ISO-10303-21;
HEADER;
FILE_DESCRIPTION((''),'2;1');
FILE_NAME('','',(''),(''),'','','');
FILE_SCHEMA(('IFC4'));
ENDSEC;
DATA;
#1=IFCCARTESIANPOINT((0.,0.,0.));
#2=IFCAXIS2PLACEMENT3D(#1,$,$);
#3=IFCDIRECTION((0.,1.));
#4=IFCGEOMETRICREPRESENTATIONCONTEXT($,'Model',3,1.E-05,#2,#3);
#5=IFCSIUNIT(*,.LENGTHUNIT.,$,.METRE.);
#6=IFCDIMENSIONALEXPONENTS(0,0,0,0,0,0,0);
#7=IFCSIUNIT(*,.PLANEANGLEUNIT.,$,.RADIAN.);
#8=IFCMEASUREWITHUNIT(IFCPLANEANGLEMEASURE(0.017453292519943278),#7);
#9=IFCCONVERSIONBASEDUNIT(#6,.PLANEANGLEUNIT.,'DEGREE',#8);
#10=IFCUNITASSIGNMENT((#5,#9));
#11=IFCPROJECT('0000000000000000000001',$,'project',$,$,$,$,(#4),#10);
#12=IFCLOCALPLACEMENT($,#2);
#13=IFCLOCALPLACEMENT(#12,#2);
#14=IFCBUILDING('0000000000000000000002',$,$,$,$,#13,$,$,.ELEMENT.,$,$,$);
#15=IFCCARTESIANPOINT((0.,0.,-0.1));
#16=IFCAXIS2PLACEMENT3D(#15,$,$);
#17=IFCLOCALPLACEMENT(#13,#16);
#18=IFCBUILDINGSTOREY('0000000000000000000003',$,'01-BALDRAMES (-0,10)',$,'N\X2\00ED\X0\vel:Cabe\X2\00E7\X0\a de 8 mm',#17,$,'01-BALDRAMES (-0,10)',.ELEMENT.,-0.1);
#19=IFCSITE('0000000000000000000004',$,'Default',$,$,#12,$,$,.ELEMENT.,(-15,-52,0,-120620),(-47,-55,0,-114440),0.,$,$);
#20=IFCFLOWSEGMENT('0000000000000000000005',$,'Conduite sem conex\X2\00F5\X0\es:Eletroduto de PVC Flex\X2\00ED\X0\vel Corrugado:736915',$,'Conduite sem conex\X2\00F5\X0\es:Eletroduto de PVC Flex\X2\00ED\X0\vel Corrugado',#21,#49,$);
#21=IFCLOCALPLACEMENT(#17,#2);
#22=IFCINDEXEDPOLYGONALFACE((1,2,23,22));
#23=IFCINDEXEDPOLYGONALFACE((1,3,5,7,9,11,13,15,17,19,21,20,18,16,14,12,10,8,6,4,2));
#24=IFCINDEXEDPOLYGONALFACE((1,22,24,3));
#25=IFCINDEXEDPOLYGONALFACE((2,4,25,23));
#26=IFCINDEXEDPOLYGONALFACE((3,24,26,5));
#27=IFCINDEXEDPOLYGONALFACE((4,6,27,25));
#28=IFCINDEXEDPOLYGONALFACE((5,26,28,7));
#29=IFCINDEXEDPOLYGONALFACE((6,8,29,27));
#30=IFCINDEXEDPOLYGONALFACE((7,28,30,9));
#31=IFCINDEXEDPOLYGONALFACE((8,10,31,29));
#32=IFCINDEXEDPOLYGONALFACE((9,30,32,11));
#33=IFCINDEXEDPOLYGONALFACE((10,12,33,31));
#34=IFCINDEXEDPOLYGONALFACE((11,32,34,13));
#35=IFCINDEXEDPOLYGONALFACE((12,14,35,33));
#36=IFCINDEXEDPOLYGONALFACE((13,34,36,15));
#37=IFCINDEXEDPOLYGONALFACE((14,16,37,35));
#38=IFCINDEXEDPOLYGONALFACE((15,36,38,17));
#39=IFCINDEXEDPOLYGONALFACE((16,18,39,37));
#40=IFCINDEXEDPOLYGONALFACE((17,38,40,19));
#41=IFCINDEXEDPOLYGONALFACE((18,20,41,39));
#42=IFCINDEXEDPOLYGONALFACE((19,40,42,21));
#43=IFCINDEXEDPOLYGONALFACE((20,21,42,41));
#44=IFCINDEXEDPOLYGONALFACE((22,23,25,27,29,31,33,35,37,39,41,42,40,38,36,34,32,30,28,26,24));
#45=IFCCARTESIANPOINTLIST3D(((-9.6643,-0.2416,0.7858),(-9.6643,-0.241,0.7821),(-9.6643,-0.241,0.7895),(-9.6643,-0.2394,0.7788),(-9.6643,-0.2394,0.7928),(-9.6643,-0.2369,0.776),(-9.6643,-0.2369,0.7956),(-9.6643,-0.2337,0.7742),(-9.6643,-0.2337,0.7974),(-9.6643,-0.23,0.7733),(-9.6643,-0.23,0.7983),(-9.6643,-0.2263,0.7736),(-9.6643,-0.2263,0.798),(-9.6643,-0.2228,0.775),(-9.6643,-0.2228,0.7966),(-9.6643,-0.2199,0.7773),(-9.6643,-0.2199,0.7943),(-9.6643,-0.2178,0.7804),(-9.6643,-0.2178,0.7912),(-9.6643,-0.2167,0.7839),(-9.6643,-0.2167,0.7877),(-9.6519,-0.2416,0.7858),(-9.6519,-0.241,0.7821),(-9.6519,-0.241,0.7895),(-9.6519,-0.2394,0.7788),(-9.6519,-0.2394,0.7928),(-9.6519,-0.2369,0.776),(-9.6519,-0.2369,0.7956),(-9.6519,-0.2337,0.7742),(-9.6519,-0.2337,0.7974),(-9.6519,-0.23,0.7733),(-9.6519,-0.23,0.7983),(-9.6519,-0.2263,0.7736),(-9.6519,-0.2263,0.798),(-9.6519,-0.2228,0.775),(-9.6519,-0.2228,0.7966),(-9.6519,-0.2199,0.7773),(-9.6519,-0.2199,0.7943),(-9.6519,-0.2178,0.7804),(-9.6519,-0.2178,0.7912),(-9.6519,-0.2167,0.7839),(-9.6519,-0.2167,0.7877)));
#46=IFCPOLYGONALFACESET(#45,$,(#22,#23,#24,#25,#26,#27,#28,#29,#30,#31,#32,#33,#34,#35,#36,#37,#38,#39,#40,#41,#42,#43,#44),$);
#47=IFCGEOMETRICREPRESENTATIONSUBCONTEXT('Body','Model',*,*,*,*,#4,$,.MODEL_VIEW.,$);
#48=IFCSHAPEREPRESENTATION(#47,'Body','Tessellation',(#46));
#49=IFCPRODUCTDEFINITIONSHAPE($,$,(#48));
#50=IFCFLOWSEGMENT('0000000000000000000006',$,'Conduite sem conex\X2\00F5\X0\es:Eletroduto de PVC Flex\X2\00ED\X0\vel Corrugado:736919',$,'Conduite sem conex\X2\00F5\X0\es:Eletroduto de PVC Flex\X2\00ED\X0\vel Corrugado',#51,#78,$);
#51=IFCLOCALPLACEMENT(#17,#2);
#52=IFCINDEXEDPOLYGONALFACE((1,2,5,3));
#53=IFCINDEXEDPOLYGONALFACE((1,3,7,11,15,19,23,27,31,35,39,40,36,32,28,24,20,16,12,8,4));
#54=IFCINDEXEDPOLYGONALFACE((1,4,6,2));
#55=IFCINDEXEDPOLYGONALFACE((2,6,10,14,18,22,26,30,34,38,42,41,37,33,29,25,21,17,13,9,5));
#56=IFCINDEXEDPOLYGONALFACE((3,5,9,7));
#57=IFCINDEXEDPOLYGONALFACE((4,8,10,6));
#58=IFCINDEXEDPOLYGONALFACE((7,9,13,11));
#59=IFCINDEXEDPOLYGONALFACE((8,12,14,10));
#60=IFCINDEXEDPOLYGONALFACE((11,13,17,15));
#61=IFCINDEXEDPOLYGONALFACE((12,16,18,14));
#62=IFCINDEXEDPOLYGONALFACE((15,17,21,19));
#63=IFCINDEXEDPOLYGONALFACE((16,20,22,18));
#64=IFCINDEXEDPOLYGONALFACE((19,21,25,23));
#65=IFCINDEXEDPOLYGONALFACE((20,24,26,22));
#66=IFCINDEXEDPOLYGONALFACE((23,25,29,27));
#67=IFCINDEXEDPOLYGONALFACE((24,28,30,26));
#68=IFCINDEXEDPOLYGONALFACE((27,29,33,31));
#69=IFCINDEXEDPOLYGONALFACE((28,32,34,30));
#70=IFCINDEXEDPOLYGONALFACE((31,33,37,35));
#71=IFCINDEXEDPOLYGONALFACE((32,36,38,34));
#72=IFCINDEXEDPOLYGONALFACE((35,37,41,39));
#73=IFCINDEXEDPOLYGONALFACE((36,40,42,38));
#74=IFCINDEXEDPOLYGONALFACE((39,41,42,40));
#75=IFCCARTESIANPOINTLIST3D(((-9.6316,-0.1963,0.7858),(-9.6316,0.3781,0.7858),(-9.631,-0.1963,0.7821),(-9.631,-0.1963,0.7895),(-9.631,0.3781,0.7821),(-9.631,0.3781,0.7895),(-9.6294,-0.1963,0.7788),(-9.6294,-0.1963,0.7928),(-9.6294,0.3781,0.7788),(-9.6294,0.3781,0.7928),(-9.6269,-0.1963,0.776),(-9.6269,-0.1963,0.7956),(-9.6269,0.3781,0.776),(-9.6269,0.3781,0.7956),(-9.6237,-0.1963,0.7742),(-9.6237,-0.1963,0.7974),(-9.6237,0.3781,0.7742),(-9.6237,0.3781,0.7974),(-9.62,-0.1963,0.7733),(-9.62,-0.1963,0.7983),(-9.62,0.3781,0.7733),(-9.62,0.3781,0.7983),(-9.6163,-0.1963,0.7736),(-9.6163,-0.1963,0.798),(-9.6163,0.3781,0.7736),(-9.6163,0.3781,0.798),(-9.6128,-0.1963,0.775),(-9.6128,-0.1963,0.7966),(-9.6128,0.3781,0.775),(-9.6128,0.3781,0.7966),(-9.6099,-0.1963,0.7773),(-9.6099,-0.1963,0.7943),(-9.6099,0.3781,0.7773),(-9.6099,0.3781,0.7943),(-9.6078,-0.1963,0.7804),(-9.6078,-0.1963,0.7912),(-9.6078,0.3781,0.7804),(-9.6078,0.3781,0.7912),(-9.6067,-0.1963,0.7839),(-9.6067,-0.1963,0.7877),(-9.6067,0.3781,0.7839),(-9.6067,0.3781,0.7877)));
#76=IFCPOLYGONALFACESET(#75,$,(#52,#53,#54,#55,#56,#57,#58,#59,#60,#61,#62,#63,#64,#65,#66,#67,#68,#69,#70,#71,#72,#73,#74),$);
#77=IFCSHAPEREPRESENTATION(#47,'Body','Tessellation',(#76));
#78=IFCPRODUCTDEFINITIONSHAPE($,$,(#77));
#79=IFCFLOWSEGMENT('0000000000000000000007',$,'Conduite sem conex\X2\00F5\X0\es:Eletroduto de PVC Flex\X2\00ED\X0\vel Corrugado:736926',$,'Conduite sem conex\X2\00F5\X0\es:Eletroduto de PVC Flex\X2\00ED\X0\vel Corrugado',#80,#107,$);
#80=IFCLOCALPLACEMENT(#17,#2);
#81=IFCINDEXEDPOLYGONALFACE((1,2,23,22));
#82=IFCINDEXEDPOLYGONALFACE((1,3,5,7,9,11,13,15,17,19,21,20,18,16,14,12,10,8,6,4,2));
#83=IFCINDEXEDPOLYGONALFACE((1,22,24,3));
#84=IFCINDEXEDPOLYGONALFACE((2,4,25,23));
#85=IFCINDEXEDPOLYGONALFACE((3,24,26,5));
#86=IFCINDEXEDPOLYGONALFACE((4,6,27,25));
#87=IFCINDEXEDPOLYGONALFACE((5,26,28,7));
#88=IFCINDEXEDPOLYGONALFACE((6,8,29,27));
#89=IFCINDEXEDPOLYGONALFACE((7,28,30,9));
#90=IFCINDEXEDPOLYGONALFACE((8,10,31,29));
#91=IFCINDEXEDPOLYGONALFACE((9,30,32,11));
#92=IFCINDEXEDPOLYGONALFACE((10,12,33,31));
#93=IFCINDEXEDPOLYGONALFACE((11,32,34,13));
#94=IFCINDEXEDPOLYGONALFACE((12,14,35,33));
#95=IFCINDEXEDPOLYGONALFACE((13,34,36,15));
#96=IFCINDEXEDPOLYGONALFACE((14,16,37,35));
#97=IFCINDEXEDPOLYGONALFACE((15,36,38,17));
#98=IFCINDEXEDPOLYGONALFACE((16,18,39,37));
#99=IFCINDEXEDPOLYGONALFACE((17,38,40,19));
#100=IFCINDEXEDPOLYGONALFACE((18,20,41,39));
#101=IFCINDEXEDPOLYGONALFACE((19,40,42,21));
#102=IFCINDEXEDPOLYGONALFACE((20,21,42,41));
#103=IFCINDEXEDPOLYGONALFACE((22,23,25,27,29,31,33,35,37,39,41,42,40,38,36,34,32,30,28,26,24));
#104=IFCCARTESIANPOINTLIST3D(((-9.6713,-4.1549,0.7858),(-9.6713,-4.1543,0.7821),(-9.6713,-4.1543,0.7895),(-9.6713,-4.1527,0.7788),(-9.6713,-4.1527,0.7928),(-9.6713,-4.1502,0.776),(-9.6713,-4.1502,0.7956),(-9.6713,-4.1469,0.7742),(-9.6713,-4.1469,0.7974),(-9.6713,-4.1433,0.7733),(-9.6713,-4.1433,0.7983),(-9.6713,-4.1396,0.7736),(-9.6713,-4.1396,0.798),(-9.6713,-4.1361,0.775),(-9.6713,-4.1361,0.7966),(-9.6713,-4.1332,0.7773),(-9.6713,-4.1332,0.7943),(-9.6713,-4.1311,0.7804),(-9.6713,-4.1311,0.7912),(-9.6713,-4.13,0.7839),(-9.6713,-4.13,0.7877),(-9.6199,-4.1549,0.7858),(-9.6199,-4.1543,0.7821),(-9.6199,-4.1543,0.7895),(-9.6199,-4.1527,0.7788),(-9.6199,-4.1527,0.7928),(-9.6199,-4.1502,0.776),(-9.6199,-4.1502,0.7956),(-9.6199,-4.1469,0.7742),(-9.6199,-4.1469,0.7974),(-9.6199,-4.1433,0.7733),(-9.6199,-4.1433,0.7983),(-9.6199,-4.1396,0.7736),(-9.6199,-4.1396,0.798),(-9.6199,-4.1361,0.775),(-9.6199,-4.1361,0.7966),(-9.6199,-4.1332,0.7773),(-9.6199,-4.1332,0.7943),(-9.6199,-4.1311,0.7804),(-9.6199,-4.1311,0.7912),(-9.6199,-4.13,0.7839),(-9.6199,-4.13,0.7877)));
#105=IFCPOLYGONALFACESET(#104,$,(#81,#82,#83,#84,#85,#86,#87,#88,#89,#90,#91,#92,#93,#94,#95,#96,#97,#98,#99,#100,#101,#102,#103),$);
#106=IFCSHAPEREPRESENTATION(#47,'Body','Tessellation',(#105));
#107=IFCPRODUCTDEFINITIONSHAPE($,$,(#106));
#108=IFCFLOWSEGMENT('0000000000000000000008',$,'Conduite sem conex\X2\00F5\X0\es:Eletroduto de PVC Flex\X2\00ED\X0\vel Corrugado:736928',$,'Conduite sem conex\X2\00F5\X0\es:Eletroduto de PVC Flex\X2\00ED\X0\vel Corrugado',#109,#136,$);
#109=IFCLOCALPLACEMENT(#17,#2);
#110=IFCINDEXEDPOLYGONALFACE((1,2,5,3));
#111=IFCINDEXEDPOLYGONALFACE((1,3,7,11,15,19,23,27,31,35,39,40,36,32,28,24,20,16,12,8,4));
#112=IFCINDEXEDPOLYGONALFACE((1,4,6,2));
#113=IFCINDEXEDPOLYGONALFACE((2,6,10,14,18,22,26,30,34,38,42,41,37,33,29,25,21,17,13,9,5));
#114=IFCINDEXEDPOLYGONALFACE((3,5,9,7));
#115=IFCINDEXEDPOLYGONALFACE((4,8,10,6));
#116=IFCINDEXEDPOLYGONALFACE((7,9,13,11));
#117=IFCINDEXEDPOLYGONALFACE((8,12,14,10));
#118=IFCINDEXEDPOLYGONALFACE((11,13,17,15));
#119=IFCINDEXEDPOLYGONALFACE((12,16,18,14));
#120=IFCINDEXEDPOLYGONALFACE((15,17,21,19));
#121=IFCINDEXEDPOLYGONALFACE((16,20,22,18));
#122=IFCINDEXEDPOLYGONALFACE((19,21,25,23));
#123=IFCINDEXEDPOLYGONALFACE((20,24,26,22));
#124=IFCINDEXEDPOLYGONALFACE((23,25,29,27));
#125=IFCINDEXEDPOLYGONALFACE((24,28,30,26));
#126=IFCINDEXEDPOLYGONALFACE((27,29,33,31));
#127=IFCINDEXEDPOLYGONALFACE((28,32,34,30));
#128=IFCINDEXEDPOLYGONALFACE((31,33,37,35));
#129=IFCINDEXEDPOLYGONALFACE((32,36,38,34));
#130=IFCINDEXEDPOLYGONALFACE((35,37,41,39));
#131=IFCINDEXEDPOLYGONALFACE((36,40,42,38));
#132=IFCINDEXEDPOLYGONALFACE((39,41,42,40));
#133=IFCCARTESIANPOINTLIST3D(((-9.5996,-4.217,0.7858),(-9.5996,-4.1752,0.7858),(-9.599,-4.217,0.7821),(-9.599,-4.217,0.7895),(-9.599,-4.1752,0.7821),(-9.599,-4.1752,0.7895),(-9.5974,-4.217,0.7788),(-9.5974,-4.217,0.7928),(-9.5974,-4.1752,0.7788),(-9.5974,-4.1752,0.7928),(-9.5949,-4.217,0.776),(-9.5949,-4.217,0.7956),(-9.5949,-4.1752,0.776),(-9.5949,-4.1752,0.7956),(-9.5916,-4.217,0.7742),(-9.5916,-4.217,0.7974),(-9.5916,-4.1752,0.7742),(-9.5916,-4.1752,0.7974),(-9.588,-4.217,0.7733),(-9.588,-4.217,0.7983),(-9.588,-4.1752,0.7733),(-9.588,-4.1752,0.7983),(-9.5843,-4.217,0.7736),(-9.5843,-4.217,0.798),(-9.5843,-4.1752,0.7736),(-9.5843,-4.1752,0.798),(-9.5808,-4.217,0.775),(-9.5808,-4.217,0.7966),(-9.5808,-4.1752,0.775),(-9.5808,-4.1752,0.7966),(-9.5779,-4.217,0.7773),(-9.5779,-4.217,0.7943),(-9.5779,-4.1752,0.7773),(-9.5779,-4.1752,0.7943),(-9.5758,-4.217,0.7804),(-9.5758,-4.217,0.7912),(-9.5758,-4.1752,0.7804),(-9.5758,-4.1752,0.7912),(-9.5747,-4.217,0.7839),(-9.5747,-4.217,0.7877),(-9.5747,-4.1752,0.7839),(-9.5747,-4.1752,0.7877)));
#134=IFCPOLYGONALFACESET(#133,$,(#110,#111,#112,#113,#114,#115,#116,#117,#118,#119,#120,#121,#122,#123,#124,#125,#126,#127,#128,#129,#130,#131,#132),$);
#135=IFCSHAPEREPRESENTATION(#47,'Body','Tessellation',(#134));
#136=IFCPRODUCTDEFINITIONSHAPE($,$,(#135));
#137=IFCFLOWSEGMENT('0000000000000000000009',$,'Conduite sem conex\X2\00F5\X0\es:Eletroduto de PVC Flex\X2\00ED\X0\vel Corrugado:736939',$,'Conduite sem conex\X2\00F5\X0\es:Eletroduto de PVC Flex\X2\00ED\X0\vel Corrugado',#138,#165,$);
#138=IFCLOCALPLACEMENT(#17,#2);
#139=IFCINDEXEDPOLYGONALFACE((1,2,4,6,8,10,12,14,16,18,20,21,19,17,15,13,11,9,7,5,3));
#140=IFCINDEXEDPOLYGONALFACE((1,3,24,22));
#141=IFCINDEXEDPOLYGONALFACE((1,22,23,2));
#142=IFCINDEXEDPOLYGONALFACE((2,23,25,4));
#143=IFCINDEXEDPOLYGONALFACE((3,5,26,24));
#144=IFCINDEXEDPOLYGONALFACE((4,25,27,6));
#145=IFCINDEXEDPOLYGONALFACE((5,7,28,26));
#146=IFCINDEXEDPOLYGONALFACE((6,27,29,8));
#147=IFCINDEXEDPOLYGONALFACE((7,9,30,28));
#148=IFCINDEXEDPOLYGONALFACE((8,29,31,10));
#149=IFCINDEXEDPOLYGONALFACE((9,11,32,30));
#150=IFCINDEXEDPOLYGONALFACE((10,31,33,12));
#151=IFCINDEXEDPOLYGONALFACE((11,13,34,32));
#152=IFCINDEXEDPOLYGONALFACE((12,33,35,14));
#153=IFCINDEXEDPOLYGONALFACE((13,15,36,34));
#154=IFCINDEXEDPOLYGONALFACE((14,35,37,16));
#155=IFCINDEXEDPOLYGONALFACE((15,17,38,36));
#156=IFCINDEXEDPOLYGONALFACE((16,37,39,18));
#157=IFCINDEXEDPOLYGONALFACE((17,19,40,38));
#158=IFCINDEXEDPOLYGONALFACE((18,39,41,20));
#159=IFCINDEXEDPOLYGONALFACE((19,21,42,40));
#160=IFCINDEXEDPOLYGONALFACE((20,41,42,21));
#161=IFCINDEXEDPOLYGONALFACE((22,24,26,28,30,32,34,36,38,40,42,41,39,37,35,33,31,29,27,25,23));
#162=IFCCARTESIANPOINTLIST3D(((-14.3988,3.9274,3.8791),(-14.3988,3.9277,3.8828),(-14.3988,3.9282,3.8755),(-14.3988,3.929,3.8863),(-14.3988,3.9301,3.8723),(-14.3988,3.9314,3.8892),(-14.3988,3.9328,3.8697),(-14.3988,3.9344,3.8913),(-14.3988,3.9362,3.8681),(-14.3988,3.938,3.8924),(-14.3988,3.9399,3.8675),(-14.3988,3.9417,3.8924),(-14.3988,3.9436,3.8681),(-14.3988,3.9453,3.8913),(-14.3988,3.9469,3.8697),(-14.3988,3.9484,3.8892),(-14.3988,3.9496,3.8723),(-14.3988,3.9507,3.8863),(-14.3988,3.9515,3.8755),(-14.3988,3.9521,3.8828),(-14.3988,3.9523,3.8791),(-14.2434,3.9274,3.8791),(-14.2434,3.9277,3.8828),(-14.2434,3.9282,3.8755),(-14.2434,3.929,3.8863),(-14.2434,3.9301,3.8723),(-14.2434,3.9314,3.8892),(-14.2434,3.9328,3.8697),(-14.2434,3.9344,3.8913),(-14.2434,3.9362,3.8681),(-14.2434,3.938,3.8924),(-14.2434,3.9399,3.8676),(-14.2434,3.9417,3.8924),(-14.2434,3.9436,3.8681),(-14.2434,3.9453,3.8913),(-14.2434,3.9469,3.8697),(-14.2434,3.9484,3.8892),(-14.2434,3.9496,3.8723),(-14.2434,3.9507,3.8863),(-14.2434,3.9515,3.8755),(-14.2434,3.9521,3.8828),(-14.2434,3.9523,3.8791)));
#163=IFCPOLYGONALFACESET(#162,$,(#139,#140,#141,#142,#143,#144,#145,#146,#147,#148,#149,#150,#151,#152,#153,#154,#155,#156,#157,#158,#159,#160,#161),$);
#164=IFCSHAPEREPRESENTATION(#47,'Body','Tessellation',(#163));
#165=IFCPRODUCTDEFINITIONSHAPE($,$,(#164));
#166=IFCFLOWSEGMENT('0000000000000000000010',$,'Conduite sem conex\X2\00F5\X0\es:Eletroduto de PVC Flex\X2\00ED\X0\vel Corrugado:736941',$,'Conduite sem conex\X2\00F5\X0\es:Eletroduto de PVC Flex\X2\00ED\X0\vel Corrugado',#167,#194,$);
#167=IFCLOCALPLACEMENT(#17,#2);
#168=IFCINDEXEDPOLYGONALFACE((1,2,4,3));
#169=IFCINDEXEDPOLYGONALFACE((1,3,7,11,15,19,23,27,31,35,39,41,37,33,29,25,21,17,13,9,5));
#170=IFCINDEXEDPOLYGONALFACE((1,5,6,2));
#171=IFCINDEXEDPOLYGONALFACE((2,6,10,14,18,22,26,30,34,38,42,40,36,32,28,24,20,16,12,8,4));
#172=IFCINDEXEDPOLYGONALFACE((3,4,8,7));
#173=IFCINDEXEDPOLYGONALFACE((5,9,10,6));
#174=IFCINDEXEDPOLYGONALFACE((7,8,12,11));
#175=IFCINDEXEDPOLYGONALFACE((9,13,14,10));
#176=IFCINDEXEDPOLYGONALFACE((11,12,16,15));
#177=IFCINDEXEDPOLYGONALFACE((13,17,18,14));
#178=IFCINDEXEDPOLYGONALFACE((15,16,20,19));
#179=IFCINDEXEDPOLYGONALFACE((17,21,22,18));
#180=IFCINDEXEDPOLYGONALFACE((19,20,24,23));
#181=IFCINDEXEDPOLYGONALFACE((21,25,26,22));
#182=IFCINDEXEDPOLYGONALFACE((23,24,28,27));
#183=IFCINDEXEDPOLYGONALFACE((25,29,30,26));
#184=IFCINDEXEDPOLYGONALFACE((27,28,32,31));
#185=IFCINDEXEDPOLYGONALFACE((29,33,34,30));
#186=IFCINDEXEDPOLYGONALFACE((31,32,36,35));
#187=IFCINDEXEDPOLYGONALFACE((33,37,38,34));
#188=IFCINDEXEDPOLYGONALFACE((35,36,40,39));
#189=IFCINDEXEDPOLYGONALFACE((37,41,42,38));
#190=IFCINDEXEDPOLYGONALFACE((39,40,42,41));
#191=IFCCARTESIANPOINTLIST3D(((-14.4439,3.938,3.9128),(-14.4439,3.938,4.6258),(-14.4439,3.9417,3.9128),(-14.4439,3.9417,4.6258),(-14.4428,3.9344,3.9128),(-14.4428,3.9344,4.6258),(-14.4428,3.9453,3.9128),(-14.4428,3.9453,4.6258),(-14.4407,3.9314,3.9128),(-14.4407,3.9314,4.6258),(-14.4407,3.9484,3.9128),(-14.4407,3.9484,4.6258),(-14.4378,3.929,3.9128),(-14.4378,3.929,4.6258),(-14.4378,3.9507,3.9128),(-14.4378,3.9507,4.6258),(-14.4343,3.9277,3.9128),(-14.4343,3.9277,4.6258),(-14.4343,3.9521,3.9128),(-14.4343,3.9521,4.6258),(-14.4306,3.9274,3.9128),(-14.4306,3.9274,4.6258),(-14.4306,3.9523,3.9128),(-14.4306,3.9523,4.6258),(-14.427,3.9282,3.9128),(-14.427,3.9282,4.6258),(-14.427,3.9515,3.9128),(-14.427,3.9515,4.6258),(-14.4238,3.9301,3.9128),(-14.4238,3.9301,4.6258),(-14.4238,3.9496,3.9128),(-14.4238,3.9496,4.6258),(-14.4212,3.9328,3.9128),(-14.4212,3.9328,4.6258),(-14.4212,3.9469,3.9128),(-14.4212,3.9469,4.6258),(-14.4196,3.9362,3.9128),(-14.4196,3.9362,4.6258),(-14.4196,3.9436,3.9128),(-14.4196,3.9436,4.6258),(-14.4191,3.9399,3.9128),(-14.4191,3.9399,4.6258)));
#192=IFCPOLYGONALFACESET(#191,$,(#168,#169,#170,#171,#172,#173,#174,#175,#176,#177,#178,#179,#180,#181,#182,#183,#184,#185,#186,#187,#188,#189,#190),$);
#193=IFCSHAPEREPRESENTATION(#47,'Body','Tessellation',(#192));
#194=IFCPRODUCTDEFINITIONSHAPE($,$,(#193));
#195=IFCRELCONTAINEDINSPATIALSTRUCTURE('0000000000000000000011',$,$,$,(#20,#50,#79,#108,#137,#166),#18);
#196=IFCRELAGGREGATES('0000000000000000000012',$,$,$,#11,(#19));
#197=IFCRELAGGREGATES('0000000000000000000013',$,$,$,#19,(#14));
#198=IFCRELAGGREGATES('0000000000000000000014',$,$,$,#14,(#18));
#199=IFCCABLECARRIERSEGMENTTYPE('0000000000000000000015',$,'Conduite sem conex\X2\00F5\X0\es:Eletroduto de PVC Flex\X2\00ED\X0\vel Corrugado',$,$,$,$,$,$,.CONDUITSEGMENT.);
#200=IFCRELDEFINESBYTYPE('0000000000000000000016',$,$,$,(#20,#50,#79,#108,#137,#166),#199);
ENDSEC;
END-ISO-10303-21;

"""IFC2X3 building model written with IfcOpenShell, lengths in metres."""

from ifc_helpers import new_model, entity, si_unit, converted_unit, direction, frame, frame_2d, origin, origin_2d_with_axis, place, context, subcontext, project, spatial, circle, extrude, type_object, element, save


model = new_model("IFC2X3")

# Units and contexts
model_context = context("Model", 3, precision=1e-05, world=origin(), true_north=direction((0.0, 1.0)))
body_context = subcontext(model_context, "Body", "Model", "MODEL_VIEW")
ifc_project = project(units=[si_unit("LENGTHUNIT", "METRE"), converted_unit("PLANEANGLEUNIT", "DEGREE", entity("IfcPlaneAngleMeasure", 0.017453292519943278), si_unit("PLANEANGLEUNIT", "RADIAN"), dimensions=[0, 0, 0, 0, 0, 0, 0])], contexts=[model_context])

# Site, building, storey
site_placement = place(None, origin())
site = spatial("IfcSite", under=ifc_project, at=site_placement, Name="Default", CompositionType="ELEMENT", RefLatitude=(-15, -52, 0, -120620), RefLongitude=(-47, -55, 0, -114440), RefElevation=0.0)
building_placement = place(site_placement, origin())
building = spatial("IfcBuilding", under=site, at=building_placement, CompositionType="ELEMENT")
storey_placement = place(building_placement, frame((0.0, 0.0, -0.1)))
storey = spatial("IfcBuildingStorey", under=building, at=storey_placement, Name="01-BALDRAMES (-0,10)", ObjectType="Nível:Cabeça de 8 mm", LongName="01-BALDRAMES (-0,10)", CompositionType="ELEMENT", Elevation=-0.1)

# Flow segments
cable_carrier_segment_type = type_object("IfcCableCarrierSegmentType", Name="Conduite sem conexões:Eletroduto de PVC Flexível Corrugado", PredefinedType="CONDUITSEGMENT")
flow_segment_1_placement = place(storey_placement, origin())
element("IfcFlowSegment", 1, at=flow_segment_1_placement, inside=storey, type_object=cable_carrier_segment_type, Name="Conduite sem conexões:Eletroduto de PVC Flexível Corrugado:736915", ObjectType="Conduite sem conexões:Eletroduto de PVC Flexível Corrugado", context=body_context, shape_type="SweptSolid", body=[
    extrude(circle(Radius=0.0125, at=frame_2d((0.0, 0.0), x_axis=(1.0, 0.0))), frame((-9.6643, -0.2291, 0.7858), z_axis=(1.0, 0.0, 0.0), x_axis=(0.0, -1.0, 0.0)), (0.0, 0.0, 1.0), 0.0124),
])
flow_segment_2_placement = place(storey_placement, origin())
element("IfcFlowSegment", 2, at=flow_segment_2_placement, inside=storey, type_object=cable_carrier_segment_type, Name="Conduite sem conexões:Eletroduto de PVC Flexível Corrugado:736919", ObjectType="Conduite sem conexões:Eletroduto de PVC Flexível Corrugado", context=body_context, shape_type="SweptSolid", body=[
    extrude(circle(Radius=0.0125, at=frame_2d((0.0, 0.0), x_axis=(1.0, 0.0))), frame((-9.6191, -0.1963, 0.7858), z_axis=(0.0, 1.0, 0.0), x_axis=(-1.0, 0.0, 0.0)), (0.0, 0.0, 1.0), 0.5744),
])
flow_segment_3_placement = place(storey_placement, origin())
element("IfcFlowSegment", 3, at=flow_segment_3_placement, inside=storey, type_object=cable_carrier_segment_type, Name="Conduite sem conexões:Eletroduto de PVC Flexível Corrugado:736926", ObjectType="Conduite sem conexões:Eletroduto de PVC Flexível Corrugado", context=body_context, shape_type="SweptSolid", body=[
    extrude(circle(Radius=0.0125, at=origin_2d_with_axis()), frame((-9.6713, -4.1424, 0.7858), z_axis=(1.0, 0.0, 0.0), x_axis=(0.0, -1.0, 0.0)), (0.0, 0.0, 1.0), 0.0514),
])
flow_segment_4_placement = place(storey_placement, origin())
element("IfcFlowSegment", 4, at=flow_segment_4_placement, inside=storey, type_object=cable_carrier_segment_type, Name="Conduite sem conexões:Eletroduto de PVC Flexível Corrugado:736928", ObjectType="Conduite sem conexões:Eletroduto de PVC Flexível Corrugado", context=body_context, shape_type="SweptSolid", body=[
    extrude(circle(Radius=0.0125, at=frame_2d((0.0, 0.0), x_axis=(1.0, 0.0))), frame((-9.5871, -4.217, 0.7858), z_axis=(0.0, 1.0, 0.0), x_axis=(-1.0, 0.0, 0.0)), (0.0, 0.0, 1.0), 0.0419),
])
flow_segment_5_placement = place(storey_placement, origin())
element("IfcFlowSegment", 5, at=flow_segment_5_placement, inside=storey, type_object=cable_carrier_segment_type, Name="Conduite sem conexões:Eletroduto de PVC Flexível Corrugado:736939", ObjectType="Conduite sem conexões:Eletroduto de PVC Flexível Corrugado", context=body_context, shape_type="SweptSolid", body=[
    extrude(circle(Radius=0.0125, at=frame_2d((0.0, 0.0), x_axis=(1.0, 0.0))), frame((-14.3988, 3.9399, 3.88), z_axis=(1.0, 0.0, 0.000008), x_axis=(0.000008, 0.0, -1.0)), (0.0, 0.0, 1.0), 0.1554),
])
flow_segment_6_placement = place(storey_placement, origin())
element("IfcFlowSegment", 6, at=flow_segment_6_placement, inside=storey, type_object=cable_carrier_segment_type, Name="Conduite sem conexões:Eletroduto de PVC Flexível Corrugado:736941", ObjectType="Conduite sem conexões:Eletroduto de PVC Flexível Corrugado", context=body_context, shape_type="SweptSolid", body=[
    extrude(circle(Radius=0.0125, at=frame_2d((0.0, 0.0), x_axis=(1.0, 0.0))), frame((-14.4316, 3.9399, 3.9128)), (0.0, 0.0, 1.0), 0.713),
])

save(model, "model.ifc")
